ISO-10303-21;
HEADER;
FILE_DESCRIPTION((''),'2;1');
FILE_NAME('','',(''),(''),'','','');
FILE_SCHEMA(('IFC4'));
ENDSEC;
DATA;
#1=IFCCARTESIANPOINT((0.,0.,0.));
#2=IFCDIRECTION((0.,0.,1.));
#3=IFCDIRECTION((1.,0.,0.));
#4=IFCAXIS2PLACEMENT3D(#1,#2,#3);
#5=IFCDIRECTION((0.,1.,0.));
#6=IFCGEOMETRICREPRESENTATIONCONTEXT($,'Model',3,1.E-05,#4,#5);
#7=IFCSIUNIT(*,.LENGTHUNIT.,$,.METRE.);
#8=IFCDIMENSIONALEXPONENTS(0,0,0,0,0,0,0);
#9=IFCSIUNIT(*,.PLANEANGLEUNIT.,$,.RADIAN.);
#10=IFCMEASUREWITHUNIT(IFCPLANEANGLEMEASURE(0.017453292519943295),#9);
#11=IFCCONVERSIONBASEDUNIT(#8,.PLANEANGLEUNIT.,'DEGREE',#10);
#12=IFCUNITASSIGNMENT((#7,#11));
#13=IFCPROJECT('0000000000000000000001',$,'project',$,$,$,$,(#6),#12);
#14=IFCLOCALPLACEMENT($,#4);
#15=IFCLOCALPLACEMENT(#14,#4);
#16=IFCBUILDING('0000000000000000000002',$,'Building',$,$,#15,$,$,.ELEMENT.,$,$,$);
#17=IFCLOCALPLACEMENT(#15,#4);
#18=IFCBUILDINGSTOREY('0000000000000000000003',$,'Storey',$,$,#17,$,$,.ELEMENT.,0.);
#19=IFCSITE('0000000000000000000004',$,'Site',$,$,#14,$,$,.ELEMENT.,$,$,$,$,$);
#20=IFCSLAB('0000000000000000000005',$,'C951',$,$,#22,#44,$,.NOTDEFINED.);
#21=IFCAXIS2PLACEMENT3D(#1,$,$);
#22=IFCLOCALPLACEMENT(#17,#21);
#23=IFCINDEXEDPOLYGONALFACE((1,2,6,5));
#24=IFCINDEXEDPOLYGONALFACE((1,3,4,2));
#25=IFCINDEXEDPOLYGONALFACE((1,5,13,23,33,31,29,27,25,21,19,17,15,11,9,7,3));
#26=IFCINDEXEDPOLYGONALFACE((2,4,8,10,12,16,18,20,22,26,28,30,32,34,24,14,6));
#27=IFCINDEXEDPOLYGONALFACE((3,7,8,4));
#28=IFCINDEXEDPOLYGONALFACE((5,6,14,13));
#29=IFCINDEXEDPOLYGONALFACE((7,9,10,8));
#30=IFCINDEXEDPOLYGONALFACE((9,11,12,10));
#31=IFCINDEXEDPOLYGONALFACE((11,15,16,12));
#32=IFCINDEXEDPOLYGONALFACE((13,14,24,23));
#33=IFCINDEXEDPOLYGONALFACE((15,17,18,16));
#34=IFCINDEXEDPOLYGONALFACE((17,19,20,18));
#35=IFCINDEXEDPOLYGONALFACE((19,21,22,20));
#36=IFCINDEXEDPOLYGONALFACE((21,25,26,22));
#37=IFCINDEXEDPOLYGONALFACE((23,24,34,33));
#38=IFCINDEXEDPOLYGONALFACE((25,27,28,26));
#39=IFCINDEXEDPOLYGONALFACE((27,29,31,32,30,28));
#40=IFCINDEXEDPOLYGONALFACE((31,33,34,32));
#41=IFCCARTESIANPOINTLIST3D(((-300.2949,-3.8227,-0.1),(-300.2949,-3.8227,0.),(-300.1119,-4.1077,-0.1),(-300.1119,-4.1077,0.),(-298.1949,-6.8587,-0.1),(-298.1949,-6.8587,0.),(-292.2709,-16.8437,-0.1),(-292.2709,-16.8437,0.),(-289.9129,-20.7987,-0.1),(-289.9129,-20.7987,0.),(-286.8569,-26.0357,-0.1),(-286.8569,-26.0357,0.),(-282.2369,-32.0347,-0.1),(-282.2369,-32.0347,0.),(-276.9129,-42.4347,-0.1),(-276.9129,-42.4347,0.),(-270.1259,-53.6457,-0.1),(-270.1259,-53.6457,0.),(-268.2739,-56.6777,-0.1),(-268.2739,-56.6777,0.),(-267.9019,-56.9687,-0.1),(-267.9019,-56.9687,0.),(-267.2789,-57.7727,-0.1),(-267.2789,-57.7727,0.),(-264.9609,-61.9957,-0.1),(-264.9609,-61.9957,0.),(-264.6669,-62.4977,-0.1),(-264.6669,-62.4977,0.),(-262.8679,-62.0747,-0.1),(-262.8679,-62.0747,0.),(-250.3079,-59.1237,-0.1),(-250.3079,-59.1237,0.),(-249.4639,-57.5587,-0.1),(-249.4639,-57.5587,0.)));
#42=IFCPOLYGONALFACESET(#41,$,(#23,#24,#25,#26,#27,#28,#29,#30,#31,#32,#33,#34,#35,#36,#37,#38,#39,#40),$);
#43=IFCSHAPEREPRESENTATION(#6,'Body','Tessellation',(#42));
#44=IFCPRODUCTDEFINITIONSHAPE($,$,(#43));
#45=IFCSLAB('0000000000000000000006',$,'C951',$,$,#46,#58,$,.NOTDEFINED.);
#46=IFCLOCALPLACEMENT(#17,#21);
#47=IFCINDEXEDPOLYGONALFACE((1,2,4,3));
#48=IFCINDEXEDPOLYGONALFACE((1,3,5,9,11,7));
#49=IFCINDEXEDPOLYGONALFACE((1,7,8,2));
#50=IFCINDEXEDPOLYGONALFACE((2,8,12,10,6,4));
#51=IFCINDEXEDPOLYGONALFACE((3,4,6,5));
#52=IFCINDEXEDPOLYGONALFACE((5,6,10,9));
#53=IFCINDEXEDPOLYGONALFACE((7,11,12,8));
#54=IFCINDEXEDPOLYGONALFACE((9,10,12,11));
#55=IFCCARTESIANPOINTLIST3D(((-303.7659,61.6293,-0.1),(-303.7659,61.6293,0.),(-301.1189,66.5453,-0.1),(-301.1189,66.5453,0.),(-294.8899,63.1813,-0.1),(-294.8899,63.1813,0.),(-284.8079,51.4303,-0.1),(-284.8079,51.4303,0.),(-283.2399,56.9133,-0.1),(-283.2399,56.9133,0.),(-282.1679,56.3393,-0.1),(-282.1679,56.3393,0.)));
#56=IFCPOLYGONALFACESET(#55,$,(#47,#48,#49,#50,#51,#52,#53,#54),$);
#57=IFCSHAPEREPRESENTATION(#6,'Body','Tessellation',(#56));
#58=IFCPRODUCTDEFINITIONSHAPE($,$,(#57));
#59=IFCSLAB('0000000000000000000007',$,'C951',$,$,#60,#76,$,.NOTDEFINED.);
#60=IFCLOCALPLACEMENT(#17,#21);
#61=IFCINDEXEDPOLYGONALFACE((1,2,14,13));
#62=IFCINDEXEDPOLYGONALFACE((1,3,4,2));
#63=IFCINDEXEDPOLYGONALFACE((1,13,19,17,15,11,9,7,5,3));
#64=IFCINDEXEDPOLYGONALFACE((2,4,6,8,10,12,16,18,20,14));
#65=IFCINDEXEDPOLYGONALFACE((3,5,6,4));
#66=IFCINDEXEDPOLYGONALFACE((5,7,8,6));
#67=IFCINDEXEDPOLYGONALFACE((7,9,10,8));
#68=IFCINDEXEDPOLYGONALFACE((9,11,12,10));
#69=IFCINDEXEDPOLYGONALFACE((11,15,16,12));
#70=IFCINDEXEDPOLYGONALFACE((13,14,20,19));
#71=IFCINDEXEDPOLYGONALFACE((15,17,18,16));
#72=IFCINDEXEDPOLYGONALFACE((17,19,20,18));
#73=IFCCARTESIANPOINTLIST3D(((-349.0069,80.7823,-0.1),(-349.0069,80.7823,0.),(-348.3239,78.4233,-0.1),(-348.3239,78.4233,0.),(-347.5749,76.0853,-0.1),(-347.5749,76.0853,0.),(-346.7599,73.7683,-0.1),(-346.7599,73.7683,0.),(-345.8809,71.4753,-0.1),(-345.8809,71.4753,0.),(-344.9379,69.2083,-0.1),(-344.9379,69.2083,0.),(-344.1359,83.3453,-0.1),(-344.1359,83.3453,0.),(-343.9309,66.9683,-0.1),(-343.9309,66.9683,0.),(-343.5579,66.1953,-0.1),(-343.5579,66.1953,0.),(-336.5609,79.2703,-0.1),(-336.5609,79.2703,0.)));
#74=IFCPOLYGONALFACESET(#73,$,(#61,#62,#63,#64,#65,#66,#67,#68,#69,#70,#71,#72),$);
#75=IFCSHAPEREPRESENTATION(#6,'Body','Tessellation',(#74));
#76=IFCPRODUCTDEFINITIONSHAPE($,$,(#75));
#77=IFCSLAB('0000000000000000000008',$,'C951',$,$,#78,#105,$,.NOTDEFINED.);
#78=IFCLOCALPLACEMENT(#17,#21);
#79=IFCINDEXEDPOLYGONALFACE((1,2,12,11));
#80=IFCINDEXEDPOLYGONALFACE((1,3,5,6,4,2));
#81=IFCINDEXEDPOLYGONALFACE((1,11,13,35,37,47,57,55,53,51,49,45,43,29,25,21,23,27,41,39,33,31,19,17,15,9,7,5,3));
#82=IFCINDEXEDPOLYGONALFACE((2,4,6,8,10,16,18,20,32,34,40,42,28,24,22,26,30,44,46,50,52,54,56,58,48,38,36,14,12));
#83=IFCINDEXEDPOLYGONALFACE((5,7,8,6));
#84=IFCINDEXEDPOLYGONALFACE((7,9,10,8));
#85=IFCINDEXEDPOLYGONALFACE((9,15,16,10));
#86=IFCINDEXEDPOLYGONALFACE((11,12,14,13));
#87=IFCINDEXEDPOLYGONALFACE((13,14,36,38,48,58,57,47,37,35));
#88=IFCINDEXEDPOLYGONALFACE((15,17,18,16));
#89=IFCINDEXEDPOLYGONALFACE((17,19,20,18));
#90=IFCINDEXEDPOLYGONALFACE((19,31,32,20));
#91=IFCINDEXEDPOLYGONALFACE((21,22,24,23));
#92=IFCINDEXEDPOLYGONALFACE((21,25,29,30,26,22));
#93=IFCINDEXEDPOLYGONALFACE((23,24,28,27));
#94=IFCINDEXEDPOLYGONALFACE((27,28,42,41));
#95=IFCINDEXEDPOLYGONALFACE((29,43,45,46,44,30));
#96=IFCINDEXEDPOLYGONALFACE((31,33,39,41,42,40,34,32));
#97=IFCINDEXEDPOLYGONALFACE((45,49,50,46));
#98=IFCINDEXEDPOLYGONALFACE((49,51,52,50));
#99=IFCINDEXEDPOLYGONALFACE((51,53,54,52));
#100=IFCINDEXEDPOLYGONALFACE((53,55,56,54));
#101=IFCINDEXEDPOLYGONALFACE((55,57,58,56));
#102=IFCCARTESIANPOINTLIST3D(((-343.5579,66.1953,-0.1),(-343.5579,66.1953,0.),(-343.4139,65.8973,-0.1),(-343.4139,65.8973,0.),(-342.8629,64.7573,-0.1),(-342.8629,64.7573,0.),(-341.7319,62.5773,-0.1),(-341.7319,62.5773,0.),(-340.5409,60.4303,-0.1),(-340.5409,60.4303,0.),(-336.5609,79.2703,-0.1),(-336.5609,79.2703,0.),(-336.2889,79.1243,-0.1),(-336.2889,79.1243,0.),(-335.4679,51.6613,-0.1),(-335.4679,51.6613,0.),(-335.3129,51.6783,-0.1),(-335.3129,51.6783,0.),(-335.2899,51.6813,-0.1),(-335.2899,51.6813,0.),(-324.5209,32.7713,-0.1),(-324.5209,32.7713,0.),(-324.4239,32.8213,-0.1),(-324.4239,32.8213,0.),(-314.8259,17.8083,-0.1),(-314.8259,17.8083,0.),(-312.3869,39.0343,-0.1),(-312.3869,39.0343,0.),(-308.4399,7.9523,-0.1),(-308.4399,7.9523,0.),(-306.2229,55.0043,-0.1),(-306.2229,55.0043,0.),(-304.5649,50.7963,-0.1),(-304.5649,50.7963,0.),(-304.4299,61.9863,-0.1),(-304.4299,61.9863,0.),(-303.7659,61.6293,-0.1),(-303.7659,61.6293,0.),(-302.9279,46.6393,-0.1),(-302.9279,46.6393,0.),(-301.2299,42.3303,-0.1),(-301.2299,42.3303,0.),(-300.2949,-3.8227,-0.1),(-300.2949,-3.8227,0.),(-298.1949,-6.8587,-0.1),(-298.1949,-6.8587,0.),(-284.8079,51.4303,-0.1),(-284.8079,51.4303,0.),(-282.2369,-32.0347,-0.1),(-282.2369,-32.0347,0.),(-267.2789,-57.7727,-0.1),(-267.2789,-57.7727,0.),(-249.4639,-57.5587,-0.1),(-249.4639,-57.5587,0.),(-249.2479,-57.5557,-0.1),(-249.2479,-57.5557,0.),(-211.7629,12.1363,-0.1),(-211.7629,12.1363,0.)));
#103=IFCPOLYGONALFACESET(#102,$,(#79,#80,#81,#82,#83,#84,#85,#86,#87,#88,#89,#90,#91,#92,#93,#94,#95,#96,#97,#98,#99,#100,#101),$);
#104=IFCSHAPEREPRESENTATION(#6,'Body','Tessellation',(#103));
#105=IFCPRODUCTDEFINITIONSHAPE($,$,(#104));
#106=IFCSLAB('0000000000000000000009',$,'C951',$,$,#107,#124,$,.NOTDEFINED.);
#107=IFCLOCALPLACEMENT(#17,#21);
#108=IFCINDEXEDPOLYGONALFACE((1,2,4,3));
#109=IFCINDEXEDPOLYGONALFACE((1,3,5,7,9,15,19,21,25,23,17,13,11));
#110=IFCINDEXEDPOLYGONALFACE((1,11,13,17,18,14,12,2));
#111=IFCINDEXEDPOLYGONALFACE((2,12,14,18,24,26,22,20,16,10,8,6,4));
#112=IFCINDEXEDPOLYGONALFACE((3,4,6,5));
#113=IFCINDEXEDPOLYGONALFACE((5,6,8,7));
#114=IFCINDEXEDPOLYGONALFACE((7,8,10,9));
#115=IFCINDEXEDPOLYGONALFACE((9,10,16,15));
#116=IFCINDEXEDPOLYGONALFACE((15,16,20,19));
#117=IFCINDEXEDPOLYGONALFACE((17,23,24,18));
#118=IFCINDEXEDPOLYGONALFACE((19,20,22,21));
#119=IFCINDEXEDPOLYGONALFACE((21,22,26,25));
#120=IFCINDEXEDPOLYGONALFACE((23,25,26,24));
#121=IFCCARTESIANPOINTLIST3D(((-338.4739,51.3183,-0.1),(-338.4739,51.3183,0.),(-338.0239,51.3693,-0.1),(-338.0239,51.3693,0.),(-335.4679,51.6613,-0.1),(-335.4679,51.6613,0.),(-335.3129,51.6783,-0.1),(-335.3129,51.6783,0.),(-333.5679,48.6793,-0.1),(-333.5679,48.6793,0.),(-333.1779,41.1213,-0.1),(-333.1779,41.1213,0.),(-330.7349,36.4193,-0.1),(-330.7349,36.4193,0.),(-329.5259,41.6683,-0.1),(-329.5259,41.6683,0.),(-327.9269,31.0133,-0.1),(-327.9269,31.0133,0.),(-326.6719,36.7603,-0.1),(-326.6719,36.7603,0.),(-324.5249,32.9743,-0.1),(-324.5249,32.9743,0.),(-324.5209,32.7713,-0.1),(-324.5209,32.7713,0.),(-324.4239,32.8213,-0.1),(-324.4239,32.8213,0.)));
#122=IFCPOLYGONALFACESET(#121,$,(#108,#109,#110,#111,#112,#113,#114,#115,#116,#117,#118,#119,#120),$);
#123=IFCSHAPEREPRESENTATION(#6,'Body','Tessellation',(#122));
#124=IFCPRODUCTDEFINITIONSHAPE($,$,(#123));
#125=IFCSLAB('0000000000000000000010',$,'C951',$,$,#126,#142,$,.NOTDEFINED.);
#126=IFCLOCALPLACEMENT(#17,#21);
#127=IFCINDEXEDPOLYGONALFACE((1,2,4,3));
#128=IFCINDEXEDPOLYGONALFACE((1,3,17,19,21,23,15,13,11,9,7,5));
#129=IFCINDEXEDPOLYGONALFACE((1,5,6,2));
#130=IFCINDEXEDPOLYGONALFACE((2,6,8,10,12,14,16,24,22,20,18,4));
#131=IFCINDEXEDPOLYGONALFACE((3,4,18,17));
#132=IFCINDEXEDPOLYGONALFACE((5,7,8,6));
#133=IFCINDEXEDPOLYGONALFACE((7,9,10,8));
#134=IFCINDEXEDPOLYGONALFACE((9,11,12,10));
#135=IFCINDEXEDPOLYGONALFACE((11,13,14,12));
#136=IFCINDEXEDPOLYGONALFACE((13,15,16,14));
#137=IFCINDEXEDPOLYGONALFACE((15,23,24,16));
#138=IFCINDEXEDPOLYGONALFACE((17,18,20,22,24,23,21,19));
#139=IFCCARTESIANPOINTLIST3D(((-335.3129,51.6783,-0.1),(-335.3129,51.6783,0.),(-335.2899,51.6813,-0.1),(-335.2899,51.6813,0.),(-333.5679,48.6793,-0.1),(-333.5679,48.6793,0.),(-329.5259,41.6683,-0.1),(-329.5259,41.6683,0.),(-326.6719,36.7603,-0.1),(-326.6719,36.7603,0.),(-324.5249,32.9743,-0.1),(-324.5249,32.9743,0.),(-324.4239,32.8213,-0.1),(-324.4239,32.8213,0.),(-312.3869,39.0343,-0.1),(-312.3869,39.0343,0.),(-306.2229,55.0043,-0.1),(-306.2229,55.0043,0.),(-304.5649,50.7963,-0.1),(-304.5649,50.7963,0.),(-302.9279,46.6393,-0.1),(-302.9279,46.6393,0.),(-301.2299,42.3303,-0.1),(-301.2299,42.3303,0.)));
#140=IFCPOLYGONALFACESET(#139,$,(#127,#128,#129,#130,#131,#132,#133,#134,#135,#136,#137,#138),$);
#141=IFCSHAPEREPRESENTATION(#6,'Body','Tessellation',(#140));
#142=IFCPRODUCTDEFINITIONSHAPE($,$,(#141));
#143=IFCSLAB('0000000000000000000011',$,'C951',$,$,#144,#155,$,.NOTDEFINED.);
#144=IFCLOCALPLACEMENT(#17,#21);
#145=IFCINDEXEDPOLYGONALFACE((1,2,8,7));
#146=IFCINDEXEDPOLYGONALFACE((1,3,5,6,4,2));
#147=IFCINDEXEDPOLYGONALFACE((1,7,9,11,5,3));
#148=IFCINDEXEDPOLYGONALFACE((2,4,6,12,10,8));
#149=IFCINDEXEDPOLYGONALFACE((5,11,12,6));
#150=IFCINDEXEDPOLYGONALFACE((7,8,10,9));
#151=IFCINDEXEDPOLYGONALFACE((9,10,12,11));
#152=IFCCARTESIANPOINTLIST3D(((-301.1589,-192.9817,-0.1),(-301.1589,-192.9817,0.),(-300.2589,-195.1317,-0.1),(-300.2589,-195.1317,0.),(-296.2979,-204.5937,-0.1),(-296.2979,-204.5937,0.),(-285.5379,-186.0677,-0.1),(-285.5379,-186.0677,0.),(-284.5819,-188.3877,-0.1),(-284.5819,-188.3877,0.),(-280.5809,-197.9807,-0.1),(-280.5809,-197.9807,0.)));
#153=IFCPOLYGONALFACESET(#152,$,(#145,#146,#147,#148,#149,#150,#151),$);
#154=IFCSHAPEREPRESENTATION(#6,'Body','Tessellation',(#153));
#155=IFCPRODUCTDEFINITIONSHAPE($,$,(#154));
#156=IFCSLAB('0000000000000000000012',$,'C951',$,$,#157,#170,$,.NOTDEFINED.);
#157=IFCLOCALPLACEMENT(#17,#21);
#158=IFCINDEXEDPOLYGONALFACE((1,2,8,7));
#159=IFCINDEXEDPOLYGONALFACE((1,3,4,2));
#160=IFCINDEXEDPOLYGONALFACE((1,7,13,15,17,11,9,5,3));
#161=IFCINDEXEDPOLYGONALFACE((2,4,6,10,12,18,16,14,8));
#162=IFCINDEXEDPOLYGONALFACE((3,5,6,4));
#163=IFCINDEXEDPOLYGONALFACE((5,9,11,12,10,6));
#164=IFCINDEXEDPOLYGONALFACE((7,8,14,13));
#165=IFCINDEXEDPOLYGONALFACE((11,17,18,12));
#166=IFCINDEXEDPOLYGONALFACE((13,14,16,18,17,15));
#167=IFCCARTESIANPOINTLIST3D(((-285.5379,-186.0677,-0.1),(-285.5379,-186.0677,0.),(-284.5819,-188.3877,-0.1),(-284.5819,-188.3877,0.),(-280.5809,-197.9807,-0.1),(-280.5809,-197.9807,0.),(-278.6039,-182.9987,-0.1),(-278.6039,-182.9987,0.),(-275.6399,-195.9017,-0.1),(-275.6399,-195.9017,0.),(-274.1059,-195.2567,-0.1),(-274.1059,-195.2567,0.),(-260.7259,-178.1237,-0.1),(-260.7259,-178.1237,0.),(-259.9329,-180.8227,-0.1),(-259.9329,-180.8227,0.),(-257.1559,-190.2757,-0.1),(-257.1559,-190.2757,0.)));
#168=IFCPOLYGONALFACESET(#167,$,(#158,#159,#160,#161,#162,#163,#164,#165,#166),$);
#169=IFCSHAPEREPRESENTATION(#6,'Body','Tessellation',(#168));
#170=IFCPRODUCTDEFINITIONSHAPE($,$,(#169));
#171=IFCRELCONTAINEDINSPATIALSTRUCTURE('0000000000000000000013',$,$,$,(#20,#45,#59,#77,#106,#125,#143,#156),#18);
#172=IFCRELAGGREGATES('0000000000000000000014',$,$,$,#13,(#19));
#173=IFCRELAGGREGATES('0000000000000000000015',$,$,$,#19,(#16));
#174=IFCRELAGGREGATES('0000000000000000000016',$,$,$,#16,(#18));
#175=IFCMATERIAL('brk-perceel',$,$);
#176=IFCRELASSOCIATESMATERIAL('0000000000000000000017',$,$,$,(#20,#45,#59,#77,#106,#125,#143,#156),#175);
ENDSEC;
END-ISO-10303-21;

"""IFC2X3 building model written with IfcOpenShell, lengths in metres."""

from ifc_helpers import new_model, entity, si_unit, converted_unit, direction, frame, origin_with_axes, place, context, project, spatial, polyline, outline, extrude, material, element, save


model = new_model("IFC2X3")

# Units and contexts
model_context = context("Model", 3, precision=1e-05, world=origin_with_axes(), true_north=direction((0.0, 1.0, 0.0)))
ifc_project = project(units=[si_unit("LENGTHUNIT", "METRE"), converted_unit("PLANEANGLEUNIT", "DEGREE", entity("IfcPlaneAngleMeasure", 0.017453292519943295), si_unit("PLANEANGLEUNIT", "RADIAN"), dimensions=[0, 0, 0, 0, 0, 0, 0])], contexts=[model_context])

# Site, building, storey
site_placement = place(None, origin_with_axes())
site = spatial("IfcSite", under=ifc_project, at=site_placement, Name="Site", CompositionType="ELEMENT")
building_placement = place(site_placement, origin_with_axes())
building = spatial("IfcBuilding", under=site, at=building_placement, Name="Building", CompositionType="ELEMENT")
storey_placement = place(building_placement, origin_with_axes())
storey = spatial("IfcBuildingStorey", under=building, at=storey_placement, Name="Storey", CompositionType="ELEMENT", Elevation=0.0)

# Slabs
ifc_material = material(Name="brk-perceel")
slab_1_placement = place(storey_placement, frame((0.0, 0.0, -0.1), z_axis=(0.0, 0.0, 1.0), x_axis=(1.0, 0.0, 0.0)))
element("IfcSlab", 1, at=slab_1_placement, inside=storey, material=ifc_material, Name="C951", PredefinedType="NOTDEFINED", context=model_context, shape_type="SweptSolid", body=[
    extrude(outline(polyline([(-286.8569, -26.0357), (-289.9129, -20.7987), (-292.2709, -16.8437), (-300.1119, -4.1077), (-300.2949, -3.8227), (-298.1949, -6.8587), (-282.2369, -32.0347), (-267.2789, -57.7727), (-249.4639, -57.5587), (-250.3079, -59.1237), (-262.8679, -62.0747), (-264.6669, -62.4977), (-264.9609, -61.9957), (-267.9019, -56.9687), (-268.2739, -56.6777), (-270.1259, -53.6457), (-276.9129, -42.4347), (-286.8569, -26.0357)])), origin_with_axes(), (0.0, 0.0, 1.0), 0.1),
])
slab_2_placement = place(storey_placement, frame((0.0, 0.0, -0.1), z_axis=(0.0, 0.0, 1.0), x_axis=(1.0, 0.0, 0.0)))
element("IfcSlab", 2, at=slab_2_placement, inside=storey, material=ifc_material, Name="C951", PredefinedType="NOTDEFINED", context=model_context, shape_type="SweptSolid", body=[
    extrude(outline(polyline([(-303.7659, 61.6293), (-301.1189, 66.5453), (-294.8899, 63.1813), (-283.2399, 56.9133), (-282.1679, 56.3393), (-284.8079, 51.4303), (-303.7659, 61.6293)])), origin_with_axes(), (0.0, 0.0, 1.0), 0.1),
])
slab_3_placement = place(storey_placement, frame((0.0, 0.0, -0.1), z_axis=(0.0, 0.0, 1.0), x_axis=(1.0, 0.0, 0.0)))
element("IfcSlab", 3, at=slab_3_placement, inside=storey, material=ifc_material, Name="C951", PredefinedType="NOTDEFINED", context=model_context, shape_type="SweptSolid", body=[
    extrude(outline(polyline([(-343.5579, 66.1953), (-343.9309, 66.9683), (-344.9379, 69.2083), (-345.8809, 71.4753), (-346.7599, 73.7683), (-347.5749, 76.0853), (-348.3239, 78.4233), (-349.0069, 80.7823), (-344.1359, 83.3453), (-336.5609, 79.2703), (-343.5579, 66.1953)])), origin_with_axes(), (0.0, 0.0, 1.0), 0.1),
])
slab_4_placement = place(storey_placement, frame((0.0, 0.0, -0.1), z_axis=(0.0, 0.0, 1.0), x_axis=(1.0, 0.0, 0.0)))
element("IfcSlab", 4, at=slab_4_placement, inside=storey, material=ifc_material, Name="C951", PredefinedType="NOTDEFINED", context=model_context, shape_type="SweptSolid", body=[
    extrude(outline(polyline([(-304.4299, 61.9863), (-303.7659, 61.6293), (-284.8079, 51.4303), (-211.7629, 12.1363), (-249.2479, -57.5557), (-249.4639, -57.5587), (-267.2789, -57.7727), (-282.2369, -32.0347), (-298.1949, -6.8587), (-300.2949, -3.8227), (-308.4399, 7.9523), (-314.8259, 17.8083), (-324.5209, 32.7713), (-324.4239, 32.8213), (-312.3869, 39.0343), (-301.2299, 42.3303), (-302.9279, 46.6393), (-304.5649, 50.7963), (-306.2229, 55.0043), (-335.2899, 51.6813), (-335.3129, 51.6783), (-335.4679, 51.6613), (-340.5409, 60.4303), (-341.7319, 62.5773), (-342.8629, 64.7573), (-343.4139, 65.8973), (-343.5579, 66.1953), (-336.5609, 79.2703), (-336.2889, 79.1243), (-304.4299, 61.9863)])), origin_with_axes(), (0.0, 0.0, 1.0), 0.1),
])
slab_5_placement = place(storey_placement, frame((0.0, 0.0, -0.1), z_axis=(0.0, 0.0, 1.0), x_axis=(1.0, 0.0, 0.0)))
element("IfcSlab", 5, at=slab_5_placement, inside=storey, material=ifc_material, Name="C951", PredefinedType="NOTDEFINED", context=model_context, shape_type="SweptSolid", body=[
    extrude(outline(polyline([(-335.3129, 51.6783), (-333.5679, 48.6793), (-329.5259, 41.6683), (-326.6719, 36.7603), (-324.5249, 32.9743), (-324.4239, 32.8213), (-324.5209, 32.7713), (-327.9269, 31.0133), (-330.7349, 36.4193), (-333.1779, 41.1213), (-338.4739, 51.3183), (-338.0239, 51.3693), (-335.4679, 51.6613), (-335.3129, 51.6783)])), origin_with_axes(), (0.0, 0.0, 1.0), 0.1),
])
slab_6_placement = place(storey_placement, frame((0.0, 0.0, -0.1), z_axis=(0.0, 0.0, 1.0), x_axis=(1.0, 0.0, 0.0)))
element("IfcSlab", 6, at=slab_6_placement, inside=storey, material=ifc_material, Name="C951", PredefinedType="NOTDEFINED", context=model_context, shape_type="SweptSolid", body=[
    extrude(outline(polyline([(-329.5259, 41.6683), (-333.5679, 48.6793), (-335.3129, 51.6783), (-335.2899, 51.6813), (-306.2229, 55.0043), (-304.5649, 50.7963), (-302.9279, 46.6393), (-301.2299, 42.3303), (-312.3869, 39.0343), (-324.4239, 32.8213), (-324.5249, 32.9743), (-326.6719, 36.7603), (-329.5259, 41.6683)])), origin_with_axes(), (0.0, 0.0, 1.0), 0.1),
])
slab_7_placement = place(storey_placement, frame((0.0, 0.0, -0.1), z_axis=(0.0, 0.0, 1.0), x_axis=(1.0, 0.0, 0.0)))
element("IfcSlab", 7, at=slab_7_placement, inside=storey, material=ifc_material, Name="C951", PredefinedType="NOTDEFINED", context=model_context, shape_type="SweptSolid", body=[
    extrude(outline(polyline([(-301.1589, -192.9817), (-285.5379, -186.0677), (-284.5819, -188.3877), (-280.5809, -197.9807), (-296.2979, -204.5937), (-300.2589, -195.1317), (-301.1589, -192.9817)])), origin_with_axes(), (0.0, 0.0, 1.0), 0.1),
])
slab_8_placement = place(storey_placement, frame((0.0, 0.0, -0.1), z_axis=(0.0, 0.0, 1.0), x_axis=(1.0, 0.0, 0.0)))
element("IfcSlab", 8, at=slab_8_placement, inside=storey, material=ifc_material, Name="C951", PredefinedType="NOTDEFINED", context=model_context, shape_type="SweptSolid", body=[
    extrude(outline(polyline([(-278.6039, -182.9987), (-260.7259, -178.1237), (-259.9329, -180.8227), (-257.1559, -190.2757), (-274.1059, -195.2567), (-275.6399, -195.9017), (-280.5809, -197.9807), (-284.5819, -188.3877), (-285.5379, -186.0677), (-278.6039, -182.9987)])), origin_with_axes(), (0.0, 0.0, 1.0), 0.1),
])

save(model, "model.ifc")
